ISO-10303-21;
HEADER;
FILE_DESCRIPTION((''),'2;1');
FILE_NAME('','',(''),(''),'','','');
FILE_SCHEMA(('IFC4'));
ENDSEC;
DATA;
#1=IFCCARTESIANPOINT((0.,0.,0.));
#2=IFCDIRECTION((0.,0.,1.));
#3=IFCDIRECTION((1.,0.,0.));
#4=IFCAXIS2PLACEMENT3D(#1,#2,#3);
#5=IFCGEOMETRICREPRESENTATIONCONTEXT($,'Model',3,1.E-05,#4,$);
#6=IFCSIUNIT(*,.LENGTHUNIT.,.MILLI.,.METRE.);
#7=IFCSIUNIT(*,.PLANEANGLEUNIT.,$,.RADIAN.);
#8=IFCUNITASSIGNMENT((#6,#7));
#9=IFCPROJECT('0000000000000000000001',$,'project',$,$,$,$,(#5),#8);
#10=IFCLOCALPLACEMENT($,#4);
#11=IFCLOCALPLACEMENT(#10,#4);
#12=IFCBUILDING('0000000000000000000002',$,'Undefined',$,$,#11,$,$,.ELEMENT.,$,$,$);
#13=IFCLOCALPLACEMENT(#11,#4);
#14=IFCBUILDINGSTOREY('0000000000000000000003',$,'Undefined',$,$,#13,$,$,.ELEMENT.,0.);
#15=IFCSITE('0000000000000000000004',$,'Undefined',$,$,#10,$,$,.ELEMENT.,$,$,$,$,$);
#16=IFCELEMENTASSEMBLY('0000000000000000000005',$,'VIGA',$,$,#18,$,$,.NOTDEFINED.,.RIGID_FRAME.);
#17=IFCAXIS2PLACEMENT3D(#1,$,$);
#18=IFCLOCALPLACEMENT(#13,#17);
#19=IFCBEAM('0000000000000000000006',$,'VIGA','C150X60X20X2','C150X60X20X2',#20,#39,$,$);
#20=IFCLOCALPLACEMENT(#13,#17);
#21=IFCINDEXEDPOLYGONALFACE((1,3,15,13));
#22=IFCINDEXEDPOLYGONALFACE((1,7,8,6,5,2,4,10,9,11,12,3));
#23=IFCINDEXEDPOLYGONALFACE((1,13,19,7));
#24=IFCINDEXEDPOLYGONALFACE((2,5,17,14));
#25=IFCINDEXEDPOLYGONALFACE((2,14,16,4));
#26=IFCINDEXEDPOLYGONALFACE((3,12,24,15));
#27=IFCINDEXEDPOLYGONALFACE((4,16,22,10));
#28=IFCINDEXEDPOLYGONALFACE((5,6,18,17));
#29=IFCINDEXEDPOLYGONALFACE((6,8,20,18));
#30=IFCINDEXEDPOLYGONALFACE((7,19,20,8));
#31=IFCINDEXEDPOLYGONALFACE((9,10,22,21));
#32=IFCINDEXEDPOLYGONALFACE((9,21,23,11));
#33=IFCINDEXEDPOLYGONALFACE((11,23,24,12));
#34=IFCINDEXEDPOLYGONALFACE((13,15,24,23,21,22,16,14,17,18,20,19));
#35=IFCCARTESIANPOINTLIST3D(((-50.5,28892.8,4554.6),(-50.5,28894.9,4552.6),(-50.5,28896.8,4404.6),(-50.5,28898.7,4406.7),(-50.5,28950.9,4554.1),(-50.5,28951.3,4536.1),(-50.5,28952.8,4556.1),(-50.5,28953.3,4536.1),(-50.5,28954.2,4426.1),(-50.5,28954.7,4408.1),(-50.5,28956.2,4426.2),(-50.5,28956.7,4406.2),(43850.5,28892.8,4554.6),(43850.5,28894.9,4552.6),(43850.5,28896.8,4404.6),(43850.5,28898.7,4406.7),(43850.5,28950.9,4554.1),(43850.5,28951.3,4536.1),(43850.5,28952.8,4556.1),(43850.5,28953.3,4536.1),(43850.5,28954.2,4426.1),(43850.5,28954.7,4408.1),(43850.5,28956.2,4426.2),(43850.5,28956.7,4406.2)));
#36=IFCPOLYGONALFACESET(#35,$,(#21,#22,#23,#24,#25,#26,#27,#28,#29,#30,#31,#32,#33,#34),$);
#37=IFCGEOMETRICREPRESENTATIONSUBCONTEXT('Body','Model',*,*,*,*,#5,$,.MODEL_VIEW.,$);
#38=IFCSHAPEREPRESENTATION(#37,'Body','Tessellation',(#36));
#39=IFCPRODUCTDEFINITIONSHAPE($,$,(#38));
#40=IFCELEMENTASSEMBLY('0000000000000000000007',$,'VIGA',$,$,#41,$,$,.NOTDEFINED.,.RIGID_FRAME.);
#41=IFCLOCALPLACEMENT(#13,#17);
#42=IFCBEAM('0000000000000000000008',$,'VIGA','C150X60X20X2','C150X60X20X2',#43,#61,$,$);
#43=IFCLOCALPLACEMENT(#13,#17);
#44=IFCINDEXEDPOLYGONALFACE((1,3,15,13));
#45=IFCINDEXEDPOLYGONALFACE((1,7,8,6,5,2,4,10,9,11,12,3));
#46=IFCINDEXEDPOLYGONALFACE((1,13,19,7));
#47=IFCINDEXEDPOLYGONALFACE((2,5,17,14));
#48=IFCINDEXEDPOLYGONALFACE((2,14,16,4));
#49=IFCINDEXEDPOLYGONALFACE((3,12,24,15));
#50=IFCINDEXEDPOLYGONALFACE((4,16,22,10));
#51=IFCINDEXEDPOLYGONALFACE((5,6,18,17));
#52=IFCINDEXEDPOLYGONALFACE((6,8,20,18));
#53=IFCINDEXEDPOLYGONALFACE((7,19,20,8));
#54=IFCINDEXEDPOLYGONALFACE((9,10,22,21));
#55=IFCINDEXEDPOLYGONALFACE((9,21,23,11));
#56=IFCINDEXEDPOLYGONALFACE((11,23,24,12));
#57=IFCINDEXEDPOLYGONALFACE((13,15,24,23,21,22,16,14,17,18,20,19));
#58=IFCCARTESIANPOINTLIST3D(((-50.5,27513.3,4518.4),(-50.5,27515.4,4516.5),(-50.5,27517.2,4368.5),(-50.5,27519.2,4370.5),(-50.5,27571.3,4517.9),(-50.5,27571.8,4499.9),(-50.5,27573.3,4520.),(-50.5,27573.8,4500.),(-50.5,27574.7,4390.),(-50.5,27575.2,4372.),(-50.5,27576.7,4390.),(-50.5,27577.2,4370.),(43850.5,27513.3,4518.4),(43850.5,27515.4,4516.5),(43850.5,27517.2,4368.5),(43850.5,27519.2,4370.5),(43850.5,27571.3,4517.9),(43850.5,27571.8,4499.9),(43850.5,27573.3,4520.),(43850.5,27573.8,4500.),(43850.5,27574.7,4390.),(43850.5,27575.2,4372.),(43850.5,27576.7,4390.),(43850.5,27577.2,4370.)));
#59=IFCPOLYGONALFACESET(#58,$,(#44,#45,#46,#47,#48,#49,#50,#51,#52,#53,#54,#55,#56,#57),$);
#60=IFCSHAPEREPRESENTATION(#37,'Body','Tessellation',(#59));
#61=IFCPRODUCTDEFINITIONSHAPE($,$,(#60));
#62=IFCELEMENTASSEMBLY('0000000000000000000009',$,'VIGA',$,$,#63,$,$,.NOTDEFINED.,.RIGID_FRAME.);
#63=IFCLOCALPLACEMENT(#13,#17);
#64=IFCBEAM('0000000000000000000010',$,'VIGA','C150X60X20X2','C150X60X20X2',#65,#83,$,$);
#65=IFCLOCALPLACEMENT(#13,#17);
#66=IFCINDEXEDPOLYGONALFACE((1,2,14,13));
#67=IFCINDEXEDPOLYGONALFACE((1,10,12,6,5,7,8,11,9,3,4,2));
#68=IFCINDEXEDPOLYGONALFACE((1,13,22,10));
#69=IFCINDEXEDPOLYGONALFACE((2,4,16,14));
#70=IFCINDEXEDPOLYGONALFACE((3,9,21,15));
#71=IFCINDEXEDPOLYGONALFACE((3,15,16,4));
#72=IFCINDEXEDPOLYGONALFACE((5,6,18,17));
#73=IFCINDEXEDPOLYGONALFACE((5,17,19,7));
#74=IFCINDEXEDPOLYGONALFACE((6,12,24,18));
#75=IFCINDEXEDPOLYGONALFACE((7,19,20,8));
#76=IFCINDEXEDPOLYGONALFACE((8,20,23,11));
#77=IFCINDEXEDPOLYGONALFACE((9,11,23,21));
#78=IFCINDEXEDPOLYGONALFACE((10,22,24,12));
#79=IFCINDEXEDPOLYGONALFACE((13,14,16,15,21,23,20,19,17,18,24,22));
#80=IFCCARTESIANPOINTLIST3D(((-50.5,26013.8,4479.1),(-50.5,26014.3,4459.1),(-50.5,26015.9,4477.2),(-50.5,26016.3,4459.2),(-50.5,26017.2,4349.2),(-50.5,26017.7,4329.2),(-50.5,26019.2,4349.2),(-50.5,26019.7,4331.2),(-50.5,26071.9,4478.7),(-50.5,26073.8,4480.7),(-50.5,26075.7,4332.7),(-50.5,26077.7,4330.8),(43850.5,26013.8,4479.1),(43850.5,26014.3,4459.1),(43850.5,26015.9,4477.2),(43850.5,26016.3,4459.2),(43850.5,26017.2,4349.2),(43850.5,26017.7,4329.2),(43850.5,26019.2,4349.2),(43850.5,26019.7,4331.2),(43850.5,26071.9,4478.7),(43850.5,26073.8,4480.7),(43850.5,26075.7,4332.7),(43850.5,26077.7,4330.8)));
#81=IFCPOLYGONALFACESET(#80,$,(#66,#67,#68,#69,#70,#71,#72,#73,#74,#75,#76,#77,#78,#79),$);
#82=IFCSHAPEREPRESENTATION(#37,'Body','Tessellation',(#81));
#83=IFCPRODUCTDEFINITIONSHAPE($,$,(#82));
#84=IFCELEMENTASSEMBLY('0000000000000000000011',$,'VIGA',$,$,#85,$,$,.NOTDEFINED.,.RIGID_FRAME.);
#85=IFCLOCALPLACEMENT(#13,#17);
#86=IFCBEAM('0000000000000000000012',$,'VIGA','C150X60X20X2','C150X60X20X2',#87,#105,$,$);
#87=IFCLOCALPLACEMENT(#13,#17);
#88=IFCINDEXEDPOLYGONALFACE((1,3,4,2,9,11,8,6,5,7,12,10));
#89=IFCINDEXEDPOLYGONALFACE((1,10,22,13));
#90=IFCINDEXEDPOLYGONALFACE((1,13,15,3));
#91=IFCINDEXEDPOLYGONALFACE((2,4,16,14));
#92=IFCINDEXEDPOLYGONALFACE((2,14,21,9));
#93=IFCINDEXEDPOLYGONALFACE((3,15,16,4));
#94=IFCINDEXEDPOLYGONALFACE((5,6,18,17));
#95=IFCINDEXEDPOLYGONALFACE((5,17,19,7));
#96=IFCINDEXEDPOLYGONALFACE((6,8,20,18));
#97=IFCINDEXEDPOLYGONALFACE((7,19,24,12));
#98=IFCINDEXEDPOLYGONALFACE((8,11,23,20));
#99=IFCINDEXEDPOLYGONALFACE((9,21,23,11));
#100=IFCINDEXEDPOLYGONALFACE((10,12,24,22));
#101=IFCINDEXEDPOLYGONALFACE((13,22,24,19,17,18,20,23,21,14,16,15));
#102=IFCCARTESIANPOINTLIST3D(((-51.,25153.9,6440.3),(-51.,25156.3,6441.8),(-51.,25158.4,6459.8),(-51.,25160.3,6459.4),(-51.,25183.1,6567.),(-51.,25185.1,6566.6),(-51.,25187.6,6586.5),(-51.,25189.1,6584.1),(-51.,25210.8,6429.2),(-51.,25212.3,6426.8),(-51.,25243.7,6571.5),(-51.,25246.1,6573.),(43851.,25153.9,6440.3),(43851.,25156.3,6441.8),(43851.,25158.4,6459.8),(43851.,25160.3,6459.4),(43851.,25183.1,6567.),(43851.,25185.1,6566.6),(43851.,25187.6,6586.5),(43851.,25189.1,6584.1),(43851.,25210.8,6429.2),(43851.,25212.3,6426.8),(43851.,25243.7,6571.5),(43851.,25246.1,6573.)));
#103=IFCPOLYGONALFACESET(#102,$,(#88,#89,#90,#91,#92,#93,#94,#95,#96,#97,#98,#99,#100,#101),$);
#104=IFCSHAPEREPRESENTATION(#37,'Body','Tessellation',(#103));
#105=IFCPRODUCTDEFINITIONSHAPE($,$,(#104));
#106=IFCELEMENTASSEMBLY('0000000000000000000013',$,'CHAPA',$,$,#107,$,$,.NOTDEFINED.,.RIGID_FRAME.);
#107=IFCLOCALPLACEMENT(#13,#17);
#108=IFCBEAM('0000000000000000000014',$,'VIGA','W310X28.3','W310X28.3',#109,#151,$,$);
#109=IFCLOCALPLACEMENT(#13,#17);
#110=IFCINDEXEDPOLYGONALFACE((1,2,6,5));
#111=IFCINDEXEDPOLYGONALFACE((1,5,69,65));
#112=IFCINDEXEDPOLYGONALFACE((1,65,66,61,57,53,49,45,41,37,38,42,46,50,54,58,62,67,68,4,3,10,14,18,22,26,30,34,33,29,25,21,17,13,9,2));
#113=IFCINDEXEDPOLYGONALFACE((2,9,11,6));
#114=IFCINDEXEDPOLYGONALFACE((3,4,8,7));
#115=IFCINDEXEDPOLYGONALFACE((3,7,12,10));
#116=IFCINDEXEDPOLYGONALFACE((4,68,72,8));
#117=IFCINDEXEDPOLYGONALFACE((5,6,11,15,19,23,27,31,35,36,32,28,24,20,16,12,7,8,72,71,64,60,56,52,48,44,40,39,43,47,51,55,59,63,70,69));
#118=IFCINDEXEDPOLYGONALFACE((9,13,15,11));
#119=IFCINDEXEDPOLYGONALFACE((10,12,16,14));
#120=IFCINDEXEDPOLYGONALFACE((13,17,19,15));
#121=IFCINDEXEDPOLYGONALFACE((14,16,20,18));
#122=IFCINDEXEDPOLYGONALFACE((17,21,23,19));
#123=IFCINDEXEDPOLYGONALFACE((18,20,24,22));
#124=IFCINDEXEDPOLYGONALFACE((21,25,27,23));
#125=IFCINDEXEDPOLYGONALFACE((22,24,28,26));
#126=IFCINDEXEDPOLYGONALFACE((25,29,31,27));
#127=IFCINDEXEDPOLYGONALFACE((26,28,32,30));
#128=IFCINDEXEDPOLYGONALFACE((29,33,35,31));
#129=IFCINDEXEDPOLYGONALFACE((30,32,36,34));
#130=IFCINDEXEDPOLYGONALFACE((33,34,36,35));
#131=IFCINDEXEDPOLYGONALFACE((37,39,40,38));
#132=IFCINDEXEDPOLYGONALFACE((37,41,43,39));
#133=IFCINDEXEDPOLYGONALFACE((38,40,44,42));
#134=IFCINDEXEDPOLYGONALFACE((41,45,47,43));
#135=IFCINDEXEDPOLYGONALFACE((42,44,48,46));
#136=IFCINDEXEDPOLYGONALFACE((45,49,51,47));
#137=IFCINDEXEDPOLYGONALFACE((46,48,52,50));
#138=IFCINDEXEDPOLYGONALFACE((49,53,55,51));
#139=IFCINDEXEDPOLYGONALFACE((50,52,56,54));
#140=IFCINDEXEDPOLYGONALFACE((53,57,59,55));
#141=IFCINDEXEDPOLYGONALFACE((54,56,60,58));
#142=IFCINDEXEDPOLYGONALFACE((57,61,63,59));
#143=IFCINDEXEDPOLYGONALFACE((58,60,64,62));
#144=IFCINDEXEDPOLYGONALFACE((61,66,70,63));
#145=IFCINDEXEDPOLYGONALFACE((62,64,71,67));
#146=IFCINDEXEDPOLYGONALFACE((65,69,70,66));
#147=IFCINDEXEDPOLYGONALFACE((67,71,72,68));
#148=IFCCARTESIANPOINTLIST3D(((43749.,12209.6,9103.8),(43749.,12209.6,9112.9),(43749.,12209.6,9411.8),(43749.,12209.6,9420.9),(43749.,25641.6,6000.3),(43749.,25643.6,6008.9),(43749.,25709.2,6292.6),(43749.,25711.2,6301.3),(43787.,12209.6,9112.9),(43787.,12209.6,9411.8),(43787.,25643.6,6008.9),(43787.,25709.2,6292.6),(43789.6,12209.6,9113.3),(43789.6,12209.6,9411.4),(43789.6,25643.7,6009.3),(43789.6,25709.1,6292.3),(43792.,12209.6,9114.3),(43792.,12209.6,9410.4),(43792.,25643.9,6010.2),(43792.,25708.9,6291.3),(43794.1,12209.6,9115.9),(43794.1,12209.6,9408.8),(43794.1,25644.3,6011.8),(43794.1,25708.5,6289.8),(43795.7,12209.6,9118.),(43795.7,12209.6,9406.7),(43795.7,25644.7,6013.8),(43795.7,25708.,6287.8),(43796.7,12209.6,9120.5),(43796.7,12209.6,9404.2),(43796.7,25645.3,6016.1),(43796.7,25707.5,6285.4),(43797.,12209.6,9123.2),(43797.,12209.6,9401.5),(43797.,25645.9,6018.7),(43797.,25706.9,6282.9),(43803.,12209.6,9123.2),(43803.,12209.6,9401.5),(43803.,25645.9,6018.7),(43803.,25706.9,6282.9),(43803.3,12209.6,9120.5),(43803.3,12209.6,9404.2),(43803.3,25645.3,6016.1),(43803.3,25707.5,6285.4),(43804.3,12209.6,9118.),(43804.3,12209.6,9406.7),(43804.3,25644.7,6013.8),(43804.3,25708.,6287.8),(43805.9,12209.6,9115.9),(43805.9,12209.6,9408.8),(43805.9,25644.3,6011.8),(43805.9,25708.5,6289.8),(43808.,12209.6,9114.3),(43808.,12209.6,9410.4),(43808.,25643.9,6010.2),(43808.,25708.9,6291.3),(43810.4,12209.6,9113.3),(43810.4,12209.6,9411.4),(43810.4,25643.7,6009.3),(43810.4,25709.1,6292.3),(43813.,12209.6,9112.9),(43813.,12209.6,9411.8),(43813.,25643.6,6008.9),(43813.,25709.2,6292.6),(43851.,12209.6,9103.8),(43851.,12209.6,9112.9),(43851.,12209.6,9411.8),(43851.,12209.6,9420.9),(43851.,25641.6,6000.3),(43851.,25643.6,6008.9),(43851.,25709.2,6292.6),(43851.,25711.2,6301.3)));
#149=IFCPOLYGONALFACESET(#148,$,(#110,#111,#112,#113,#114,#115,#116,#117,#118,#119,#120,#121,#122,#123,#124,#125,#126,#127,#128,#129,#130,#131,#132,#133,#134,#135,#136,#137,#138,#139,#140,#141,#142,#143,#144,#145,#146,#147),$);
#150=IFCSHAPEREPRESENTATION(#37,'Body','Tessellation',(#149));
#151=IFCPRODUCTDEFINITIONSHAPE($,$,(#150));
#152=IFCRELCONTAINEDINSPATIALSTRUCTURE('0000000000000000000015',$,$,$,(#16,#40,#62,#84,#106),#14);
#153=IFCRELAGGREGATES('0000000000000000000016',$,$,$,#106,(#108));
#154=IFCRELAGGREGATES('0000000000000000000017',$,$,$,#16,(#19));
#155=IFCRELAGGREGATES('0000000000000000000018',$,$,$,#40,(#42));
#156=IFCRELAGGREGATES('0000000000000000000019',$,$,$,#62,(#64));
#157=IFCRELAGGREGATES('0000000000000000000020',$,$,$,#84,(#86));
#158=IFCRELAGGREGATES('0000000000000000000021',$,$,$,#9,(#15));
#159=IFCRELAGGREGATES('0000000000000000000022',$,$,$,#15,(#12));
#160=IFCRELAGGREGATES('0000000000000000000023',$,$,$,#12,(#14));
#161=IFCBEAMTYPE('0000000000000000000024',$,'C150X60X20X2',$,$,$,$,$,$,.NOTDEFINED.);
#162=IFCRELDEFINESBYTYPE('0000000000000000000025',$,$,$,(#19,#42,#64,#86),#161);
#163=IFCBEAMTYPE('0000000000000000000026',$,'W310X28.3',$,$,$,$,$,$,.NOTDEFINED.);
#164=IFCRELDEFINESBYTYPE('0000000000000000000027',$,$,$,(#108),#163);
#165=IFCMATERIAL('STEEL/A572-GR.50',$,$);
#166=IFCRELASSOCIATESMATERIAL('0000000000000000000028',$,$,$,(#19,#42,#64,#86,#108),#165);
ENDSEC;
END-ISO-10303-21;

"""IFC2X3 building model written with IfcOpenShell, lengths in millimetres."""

from ifc_helpers import new_model, si_unit, frame, origin_with_axes, origin_2d_with_axis, place, context, subcontext, project, spatial, i_section, c_section, extrude, clip, halfspace, material, type_object, element, aggregate, save


model = new_model("IFC2X3")

# Units and contexts
model_context = context("Model", 3, precision=1e-05, world=origin_with_axes())
body_context = subcontext(model_context, "Body", "Model", "MODEL_VIEW")
ifc_project = project(units=[si_unit("LENGTHUNIT", "METRE", prefix="MILLI"), si_unit("PLANEANGLEUNIT", "RADIAN")], contexts=[model_context])

# Site, building, storey
site_placement = place(None, origin_with_axes())
site = spatial("IfcSite", under=ifc_project, at=site_placement, Name="Undefined", CompositionType="ELEMENT")
building_placement = place(site_placement, origin_with_axes())
building = spatial("IfcBuilding", under=site, at=building_placement, Name="Undefined", CompositionType="ELEMENT")
storey_placement = place(building_placement, origin_with_axes())
storey = spatial("IfcBuildingStorey", under=building, at=storey_placement, Name="Undefined", CompositionType="ELEMENT", Elevation=0.0)

# Element assemblies, beams
assembly_1_placement = place(storey_placement, origin_with_axes())
assembly_1 = element("IfcElementAssembly", 1, at=assembly_1_placement, inside=storey, Name="VIGA", AssemblyPlace="NOTDEFINED", PredefinedType="RIGID_FRAME")
ifc_material_1 = material(Name="STEEL/A572-GR.50")
beam_type_1 = type_object("IfcBeamType", Name="C150X60X20X2", PredefinedType="NOTDEFINED")
beam_1_placement = place(assembly_1_placement, frame((43850.5, 28924.8, 4480.4), z_axis=(0.0, -0.026187, 0.999657), x_axis=(-1.0, 0.0, 0.0)))
beam_1 = element("IfcBeam", 2, at=beam_1_placement, type_object=beam_type_1, material=ifc_material_1, Name="VIGA", Description="C150X60X20X2", ObjectType="C150X60X20X2", context=body_context, shape_type="SweptSolid", body=[
    extrude(c_section(Depth=150.0, Width=60.0, WallThickness=2.0, Girth=20.0, at=origin_2d_with_axis()), frame((43901.0, 0.0, 0.0), z_axis=(-1.0, 0.0, 0.0), x_axis=(0.0, -1.0, 0.0)), (0.0, 0.0, 1.0), 43901.0),
])
assembly_2_placement = place(storey_placement, origin_with_axes())
assembly_2 = element("IfcElementAssembly", 3, at=assembly_2_placement, inside=storey, Name="VIGA", AssemblyPlace="NOTDEFINED", PredefinedType="RIGID_FRAME")
beam_2_placement = place(assembly_2_placement, frame((43850.5, 27545.3, 4444.2), z_axis=(0.0, -0.026187, 0.999657), x_axis=(-1.0, 0.0, 0.0)))
beam_2 = element("IfcBeam", 4, at=beam_2_placement, type_object=beam_type_1, material=ifc_material_1, Name="VIGA", Description="C150X60X20X2", ObjectType="C150X60X20X2", context=body_context, shape_type="SweptSolid", body=[
    extrude(c_section(Depth=150.0, Width=60.0, WallThickness=2.0, Girth=20.0, at=origin_2d_with_axis()), frame((43901.0, 0.0, 0.0), z_axis=(-1.0, 0.0, 0.0), x_axis=(0.0, -1.0, 0.0)), (0.0, 0.0, 1.0), 43901.0),
])
assembly_3_placement = place(storey_placement, origin_with_axes())
assembly_3 = element("IfcElementAssembly", 5, at=assembly_3_placement, inside=storey, Name="VIGA", AssemblyPlace="NOTDEFINED", PredefinedType="RIGID_FRAME")
beam_3_placement = place(assembly_3_placement, frame((43850.5, 26045.8, 4404.9), z_axis=(0.0, 0.026187, -0.999657), x_axis=(-1.0, 0.0, 0.0)))
beam_3 = element("IfcBeam", 6, at=beam_3_placement, type_object=beam_type_1, material=ifc_material_1, Name="VIGA", Description="C150X60X20X2", ObjectType="C150X60X20X2", context=body_context, shape_type="SweptSolid", body=[
    extrude(c_section(Depth=150.0, Width=60.0, WallThickness=2.0, Girth=20.0, at=origin_2d_with_axis()), frame((43901.0, 0.0, 0.0), z_axis=(-1.0, 0.0, 0.0), x_axis=(0.0, -1.0, 0.0)), (0.0, 0.0, 1.0), 43901.0),
])
assembly_4_placement = place(storey_placement, origin_with_axes())
assembly_4 = element("IfcElementAssembly", 7, at=assembly_4_placement, inside=storey, Name="VIGA", AssemblyPlace="NOTDEFINED", PredefinedType="RIGID_FRAME")
beam_4_placement = place(assembly_4_placement, frame((43851.0, 25200.0, 6506.7), z_axis=(0.0, -0.225124, -0.97433), x_axis=(-1.0, 0.0, 0.0)))
beam_4 = element("IfcBeam", 8, at=beam_4_placement, type_object=beam_type_1, material=ifc_material_1, Name="VIGA", Description="C150X60X20X2", ObjectType="C150X60X20X2", context=body_context, shape_type="SweptSolid", body=[
    extrude(c_section(Depth=150.0, Width=60.0, WallThickness=2.0, Girth=20.0, at=origin_2d_with_axis()), frame((43902.0, 0.0, 0.0), z_axis=(-1.0, 0.0, 0.0), x_axis=(0.0, -1.0, 0.0)), (0.0, 0.0, 1.0), 43902.0),
])
assembly_5_placement = place(storey_placement, origin_with_axes())
assembly_5 = element("IfcElementAssembly", 9, at=assembly_5_placement, inside=storey, Name="CHAPA", AssemblyPlace="NOTDEFINED", PredefinedType="RIGID_FRAME")
beam_type_2 = type_object("IfcBeamType", Name="W310X28.3", PredefinedType="NOTDEFINED")
beam_5_placement = place(assembly_5_placement, frame((43800.0, 25676.4, 6150.8), z_axis=(0.0, -0.225124, -0.97433), x_axis=(0.0, -0.97433, 0.225124)))
beam_5 = element("IfcBeam", 10, at=beam_5_placement, type_object=beam_type_2, material=ifc_material_1, Name="VIGA", Description="W310X28.3", ObjectType="W310X28.3", context=body_context, shape_type="Clipping", body=[
    clip(extrude(i_section(OverallWidth=102.0, OverallDepth=309.0, WebThickness=6.0, FlangeThickness=8.9, FilletRadius=10.0, at=origin_2d_with_axis()), frame((13995.7, 0.0, 0.0), z_axis=(-1.0, 0.0, 0.0), x_axis=(0.0, -1.0, 0.0)), (0.0, 0.0, 1.0), 13995.7), halfspace(frame((13786.4, 0.0, 152.3), z_axis=(0.97433, 0.0, 0.225124), x_axis=(0.225124, 0.0, -0.97433)), False)),
])

aggregate(assembly_5, [beam_5])

aggregate(assembly_1, [beam_1])
aggregate(assembly_2, [beam_2])
aggregate(assembly_3, [beam_3])
aggregate(assembly_4, [beam_4])

save(model, "model.ifc")
